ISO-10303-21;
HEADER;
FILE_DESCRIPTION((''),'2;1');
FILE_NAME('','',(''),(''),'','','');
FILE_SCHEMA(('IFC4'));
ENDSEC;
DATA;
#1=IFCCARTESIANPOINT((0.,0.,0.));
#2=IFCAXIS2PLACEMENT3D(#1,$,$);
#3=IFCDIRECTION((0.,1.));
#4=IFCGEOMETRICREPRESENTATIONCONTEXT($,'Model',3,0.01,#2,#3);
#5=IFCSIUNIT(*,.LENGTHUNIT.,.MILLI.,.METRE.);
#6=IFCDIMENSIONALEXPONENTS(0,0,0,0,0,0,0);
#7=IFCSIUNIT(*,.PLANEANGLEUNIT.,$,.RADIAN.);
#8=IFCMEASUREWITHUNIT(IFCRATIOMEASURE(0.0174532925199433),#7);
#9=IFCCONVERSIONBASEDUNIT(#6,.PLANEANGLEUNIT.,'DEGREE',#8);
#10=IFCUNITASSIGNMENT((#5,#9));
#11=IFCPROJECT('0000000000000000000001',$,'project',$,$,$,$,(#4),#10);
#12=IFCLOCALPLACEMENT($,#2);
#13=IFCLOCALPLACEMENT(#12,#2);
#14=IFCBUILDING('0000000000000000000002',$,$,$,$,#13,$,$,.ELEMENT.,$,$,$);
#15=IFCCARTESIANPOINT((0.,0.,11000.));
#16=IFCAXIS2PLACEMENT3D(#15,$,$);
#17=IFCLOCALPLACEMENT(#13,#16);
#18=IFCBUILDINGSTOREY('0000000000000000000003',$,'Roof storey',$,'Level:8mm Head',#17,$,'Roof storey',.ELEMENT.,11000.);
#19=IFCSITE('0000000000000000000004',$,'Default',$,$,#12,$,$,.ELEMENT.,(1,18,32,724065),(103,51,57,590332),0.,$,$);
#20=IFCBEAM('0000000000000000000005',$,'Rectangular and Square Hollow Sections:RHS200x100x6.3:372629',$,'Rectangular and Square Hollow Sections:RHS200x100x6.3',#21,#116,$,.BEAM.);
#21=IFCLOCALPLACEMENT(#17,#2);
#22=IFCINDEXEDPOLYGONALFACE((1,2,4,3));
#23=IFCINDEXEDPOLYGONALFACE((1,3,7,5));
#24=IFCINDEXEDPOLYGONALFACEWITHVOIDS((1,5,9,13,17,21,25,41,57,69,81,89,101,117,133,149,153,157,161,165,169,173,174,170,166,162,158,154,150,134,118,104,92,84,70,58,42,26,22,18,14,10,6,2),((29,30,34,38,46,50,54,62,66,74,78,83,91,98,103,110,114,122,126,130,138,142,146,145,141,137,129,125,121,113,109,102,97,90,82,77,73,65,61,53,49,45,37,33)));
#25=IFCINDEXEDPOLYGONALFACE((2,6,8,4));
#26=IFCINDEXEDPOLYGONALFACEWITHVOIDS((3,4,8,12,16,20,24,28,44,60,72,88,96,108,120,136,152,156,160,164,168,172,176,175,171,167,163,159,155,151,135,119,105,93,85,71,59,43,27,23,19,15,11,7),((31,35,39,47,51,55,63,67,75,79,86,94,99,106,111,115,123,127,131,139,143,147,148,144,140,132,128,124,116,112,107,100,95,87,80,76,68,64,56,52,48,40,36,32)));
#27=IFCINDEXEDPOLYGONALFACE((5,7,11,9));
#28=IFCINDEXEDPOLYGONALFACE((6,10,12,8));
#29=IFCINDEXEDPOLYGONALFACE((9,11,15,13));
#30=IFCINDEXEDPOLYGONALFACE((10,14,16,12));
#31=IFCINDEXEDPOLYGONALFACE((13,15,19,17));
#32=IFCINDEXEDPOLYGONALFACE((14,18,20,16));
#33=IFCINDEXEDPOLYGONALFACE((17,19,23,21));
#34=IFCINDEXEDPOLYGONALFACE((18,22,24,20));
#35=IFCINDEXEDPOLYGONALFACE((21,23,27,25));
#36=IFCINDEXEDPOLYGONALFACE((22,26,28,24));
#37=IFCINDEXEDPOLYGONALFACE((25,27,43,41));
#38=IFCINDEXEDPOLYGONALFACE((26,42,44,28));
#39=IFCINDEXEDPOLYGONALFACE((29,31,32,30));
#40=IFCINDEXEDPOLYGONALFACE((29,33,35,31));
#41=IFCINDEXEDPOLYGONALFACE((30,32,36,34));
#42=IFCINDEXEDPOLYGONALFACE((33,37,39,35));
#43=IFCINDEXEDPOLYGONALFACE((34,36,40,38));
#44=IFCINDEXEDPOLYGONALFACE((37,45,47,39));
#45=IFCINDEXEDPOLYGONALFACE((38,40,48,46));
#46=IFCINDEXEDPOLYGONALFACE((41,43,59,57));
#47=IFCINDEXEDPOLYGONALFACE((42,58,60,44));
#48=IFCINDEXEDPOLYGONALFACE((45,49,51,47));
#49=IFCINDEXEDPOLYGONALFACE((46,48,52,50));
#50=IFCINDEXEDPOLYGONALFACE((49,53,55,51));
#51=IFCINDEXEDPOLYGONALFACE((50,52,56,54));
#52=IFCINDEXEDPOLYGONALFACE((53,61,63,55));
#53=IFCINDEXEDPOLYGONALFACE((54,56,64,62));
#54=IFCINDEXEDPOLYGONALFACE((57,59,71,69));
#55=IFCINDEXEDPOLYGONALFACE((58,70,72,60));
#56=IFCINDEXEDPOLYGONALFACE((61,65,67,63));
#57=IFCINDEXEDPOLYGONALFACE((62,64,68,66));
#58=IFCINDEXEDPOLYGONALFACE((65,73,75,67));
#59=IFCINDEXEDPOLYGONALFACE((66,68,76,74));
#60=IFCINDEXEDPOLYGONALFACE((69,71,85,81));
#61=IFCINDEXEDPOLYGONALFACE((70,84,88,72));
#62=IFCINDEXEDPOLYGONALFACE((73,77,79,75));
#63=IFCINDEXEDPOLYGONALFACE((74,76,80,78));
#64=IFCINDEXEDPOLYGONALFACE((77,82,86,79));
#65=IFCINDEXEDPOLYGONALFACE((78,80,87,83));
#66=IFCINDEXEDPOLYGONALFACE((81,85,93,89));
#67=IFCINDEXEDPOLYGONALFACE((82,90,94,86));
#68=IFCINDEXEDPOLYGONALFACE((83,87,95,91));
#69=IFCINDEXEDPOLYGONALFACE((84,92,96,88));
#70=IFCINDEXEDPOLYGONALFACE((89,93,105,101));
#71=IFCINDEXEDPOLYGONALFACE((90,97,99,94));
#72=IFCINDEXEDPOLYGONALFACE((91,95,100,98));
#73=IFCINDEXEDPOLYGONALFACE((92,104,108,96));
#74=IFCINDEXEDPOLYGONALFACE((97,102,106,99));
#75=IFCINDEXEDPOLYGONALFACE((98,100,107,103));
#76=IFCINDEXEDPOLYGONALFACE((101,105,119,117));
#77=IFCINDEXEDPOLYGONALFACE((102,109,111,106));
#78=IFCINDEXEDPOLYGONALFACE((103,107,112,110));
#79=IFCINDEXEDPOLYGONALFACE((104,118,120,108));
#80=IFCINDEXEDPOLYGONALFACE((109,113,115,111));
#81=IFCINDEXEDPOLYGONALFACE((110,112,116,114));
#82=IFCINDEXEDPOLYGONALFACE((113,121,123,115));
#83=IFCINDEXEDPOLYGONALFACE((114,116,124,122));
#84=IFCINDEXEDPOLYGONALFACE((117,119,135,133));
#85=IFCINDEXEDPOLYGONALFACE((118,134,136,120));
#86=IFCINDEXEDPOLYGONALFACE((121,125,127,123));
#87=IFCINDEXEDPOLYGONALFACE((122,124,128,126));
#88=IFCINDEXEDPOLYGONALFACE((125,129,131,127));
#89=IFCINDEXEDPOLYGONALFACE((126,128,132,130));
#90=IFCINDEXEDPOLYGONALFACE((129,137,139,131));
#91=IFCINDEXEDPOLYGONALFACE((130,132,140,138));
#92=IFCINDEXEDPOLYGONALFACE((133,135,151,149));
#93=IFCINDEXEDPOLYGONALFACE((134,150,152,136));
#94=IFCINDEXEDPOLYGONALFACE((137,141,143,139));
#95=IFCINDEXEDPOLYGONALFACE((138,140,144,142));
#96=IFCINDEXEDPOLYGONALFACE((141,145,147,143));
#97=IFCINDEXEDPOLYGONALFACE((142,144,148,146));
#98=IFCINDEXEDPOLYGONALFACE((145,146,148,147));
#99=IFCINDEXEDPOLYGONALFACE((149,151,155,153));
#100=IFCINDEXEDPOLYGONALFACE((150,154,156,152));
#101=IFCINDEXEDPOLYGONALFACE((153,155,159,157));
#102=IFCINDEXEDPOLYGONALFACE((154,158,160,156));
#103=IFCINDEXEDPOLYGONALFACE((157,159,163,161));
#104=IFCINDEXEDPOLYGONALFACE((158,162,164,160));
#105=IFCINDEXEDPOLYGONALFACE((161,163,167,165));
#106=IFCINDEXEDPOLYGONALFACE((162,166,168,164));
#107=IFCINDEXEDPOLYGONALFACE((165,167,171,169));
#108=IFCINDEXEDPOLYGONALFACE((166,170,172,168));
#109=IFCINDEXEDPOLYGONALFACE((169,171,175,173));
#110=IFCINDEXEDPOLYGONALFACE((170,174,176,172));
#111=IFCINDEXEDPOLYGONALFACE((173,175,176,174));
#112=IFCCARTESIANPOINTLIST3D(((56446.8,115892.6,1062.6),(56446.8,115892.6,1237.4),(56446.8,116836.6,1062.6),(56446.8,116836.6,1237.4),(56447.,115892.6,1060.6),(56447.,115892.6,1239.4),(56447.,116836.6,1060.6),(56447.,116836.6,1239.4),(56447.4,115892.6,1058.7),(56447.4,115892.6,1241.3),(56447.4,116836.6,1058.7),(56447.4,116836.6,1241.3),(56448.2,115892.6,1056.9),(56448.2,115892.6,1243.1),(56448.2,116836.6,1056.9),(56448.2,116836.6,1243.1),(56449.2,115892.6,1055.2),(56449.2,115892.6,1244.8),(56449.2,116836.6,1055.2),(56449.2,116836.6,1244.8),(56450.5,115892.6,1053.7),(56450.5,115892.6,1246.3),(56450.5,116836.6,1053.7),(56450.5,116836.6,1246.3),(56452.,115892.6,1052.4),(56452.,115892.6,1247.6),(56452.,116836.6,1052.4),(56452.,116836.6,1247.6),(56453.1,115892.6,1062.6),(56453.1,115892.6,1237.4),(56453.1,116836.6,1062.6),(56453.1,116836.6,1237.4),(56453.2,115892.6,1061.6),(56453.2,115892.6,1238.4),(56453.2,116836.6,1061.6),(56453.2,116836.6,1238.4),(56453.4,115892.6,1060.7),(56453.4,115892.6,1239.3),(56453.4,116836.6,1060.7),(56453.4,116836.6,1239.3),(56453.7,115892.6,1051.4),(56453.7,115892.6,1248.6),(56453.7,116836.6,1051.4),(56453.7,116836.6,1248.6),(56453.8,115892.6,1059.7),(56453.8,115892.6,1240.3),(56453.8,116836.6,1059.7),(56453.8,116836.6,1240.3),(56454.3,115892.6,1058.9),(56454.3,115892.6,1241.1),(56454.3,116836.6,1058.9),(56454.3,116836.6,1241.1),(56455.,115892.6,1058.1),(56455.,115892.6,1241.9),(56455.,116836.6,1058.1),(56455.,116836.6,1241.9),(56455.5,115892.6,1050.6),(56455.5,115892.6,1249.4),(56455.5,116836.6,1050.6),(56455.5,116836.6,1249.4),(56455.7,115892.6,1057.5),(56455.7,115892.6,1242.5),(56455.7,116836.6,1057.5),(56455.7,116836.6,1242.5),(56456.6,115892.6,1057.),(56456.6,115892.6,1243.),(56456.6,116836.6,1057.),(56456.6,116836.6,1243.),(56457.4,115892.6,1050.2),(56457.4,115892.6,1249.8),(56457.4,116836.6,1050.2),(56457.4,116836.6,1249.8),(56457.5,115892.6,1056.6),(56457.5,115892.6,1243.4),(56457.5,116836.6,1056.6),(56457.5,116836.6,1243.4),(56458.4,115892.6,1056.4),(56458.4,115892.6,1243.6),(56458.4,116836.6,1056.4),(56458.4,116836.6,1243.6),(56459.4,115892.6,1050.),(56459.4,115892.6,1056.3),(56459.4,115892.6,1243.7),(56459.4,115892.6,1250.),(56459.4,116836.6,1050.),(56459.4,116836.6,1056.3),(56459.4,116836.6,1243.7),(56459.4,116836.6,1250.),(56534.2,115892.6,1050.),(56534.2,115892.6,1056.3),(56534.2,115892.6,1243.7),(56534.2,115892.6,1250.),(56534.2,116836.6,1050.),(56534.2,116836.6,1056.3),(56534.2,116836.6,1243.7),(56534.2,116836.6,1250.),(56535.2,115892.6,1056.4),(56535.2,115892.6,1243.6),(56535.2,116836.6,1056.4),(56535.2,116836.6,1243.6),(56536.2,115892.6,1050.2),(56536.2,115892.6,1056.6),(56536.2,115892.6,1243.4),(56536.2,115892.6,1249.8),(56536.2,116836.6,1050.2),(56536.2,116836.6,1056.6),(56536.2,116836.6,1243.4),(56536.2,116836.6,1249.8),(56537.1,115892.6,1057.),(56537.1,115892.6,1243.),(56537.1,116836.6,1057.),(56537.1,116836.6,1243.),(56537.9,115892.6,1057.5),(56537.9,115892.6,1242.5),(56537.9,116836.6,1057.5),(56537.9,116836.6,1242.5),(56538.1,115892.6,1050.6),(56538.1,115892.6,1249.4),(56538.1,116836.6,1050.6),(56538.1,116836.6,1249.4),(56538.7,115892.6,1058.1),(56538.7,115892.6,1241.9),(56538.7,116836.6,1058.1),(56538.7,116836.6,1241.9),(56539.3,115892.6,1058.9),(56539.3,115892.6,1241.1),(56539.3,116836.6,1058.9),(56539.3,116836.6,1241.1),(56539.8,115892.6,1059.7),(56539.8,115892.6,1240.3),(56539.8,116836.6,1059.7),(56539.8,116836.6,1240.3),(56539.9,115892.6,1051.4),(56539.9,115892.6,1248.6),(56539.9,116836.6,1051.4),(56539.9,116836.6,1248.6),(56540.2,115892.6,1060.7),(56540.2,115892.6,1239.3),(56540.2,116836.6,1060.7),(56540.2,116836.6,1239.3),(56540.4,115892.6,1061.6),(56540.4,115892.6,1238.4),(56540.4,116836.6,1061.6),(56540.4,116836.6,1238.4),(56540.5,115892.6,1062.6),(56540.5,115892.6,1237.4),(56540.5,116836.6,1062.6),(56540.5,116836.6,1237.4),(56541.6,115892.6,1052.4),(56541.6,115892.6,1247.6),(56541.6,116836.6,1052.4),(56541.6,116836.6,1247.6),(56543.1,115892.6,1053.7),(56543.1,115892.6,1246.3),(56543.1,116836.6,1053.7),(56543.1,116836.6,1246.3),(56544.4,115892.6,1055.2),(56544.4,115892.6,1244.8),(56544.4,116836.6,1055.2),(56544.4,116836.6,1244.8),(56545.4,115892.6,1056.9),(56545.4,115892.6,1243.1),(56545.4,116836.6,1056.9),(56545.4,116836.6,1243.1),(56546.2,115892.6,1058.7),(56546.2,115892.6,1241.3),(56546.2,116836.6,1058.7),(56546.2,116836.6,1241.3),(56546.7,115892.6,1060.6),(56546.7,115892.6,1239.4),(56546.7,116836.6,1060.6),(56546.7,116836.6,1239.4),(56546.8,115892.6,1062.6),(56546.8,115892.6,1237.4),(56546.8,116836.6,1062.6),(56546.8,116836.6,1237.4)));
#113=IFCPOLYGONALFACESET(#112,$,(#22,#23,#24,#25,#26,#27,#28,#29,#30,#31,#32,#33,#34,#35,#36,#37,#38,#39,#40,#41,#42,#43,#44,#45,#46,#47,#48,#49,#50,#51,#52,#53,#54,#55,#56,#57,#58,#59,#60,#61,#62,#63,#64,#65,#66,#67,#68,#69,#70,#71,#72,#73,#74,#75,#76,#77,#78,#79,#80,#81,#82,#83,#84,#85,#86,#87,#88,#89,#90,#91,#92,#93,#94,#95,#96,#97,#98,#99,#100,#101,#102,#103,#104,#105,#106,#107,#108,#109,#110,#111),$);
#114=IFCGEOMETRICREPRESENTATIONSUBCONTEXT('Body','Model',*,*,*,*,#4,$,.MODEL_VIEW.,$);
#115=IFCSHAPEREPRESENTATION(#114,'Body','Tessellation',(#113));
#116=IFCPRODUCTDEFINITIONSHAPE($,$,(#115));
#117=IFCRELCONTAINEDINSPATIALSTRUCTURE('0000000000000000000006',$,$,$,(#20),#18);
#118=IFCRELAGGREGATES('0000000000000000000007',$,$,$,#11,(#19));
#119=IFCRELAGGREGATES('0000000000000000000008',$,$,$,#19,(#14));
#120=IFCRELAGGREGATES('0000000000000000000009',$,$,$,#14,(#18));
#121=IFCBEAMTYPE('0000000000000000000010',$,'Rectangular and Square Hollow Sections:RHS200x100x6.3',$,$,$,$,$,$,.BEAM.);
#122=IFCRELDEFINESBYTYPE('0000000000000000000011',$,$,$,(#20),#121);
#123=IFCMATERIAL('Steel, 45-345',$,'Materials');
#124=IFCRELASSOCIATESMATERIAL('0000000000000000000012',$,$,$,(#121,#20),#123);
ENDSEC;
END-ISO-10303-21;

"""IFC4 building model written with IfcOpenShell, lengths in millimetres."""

from ifc_helpers import new_model, entity, si_unit, converted_unit, direction, frame, origin, place, context, subcontext, project, spatial, indexed_curve, outline, extrude, source, transform, mapped, material, type_object, type_shapes, element, save


model = new_model("IFC4")

# Units and contexts
model_context = context("Model", 3, precision=0.01, world=origin(), true_north=direction((0.0, 1.0)))
body_context = subcontext(model_context, "Body", "Model", "MODEL_VIEW")
ifc_project = project(units=[si_unit("LENGTHUNIT", "METRE", prefix="MILLI"), converted_unit("PLANEANGLEUNIT", "DEGREE", entity("IfcRatioMeasure", 0.0174532925199433), si_unit("PLANEANGLEUNIT", "RADIAN"), dimensions=[0, 0, 0, 0, 0, 0, 0])], contexts=[model_context])

# Site, building, storey
site_placement = place(None, origin())
site = spatial("IfcSite", under=ifc_project, at=site_placement, Name="Default", CompositionType="ELEMENT", RefLatitude=(1, 18, 32, 724065), RefLongitude=(103, 51, 57, 590332), RefElevation=0.0)
building_placement = place(site_placement, origin())
building = spatial("IfcBuilding", under=site, at=building_placement, CompositionType="ELEMENT")
storey_placement = place(building_placement, frame((0.0, 0.0, 11000.0)))
storey = spatial("IfcBuildingStorey", under=building, at=storey_placement, Name="Roof storey", ObjectType="Level:8mm Head", LongName="Roof storey", CompositionType="ELEMENT", Elevation=11000.0)

# Shared definitions
ifc_material = material(Name="Steel, 45-345", Category="Materials")

# Beam
beam_type_1 = type_object("IfcBeamType", Name="Rectangular and Square Hollow Sections:RHS200x100x6.3", PredefinedType="BEAM", material=ifc_material)
shared_shape_1 = source(origin(), body_context, "Body", "SweptSolid", [
    extrude(outline(indexed_curve([(-50.0, -87.4), (-49.8, -89.4), (-49.4, -91.3), (-48.6, -93.1), (-47.6, -94.8), (-46.3, -96.3), (-44.8, -97.6), (-43.1, -98.6), (-41.3, -99.4), (-39.4, -99.8), (-37.4, -100.0), (37.4, -100.0), (39.4, -99.8), (41.3, -99.4), (43.1, -98.6), (44.8, -97.6), (46.3, -96.3), (47.6, -94.8), (48.6, -93.1), (49.4, -91.3), (49.8, -89.4), (50.0, -87.4), (50.0, 87.4), (49.8, 89.4), (49.4, 91.3), (48.6, 93.1), (47.6, 94.8), (46.3, 96.3), (44.8, 97.6), (43.1, 98.6), (41.3, 99.4), (39.4, 99.8), (37.4, 100.0), (-37.4, 100.0), (-39.4, 99.8), (-41.3, 99.4), (-43.1, 98.6), (-44.8, 97.6), (-46.3, 96.3), (-47.6, 94.8), (-48.6, 93.1), (-49.4, 91.3), (-49.8, 89.4), (-50.0, 87.4), (-50.0, -87.4)], self_intersect=False), holes=[indexed_curve([(37.4, -93.7), (-37.4, -93.7), (-38.4, -93.6), (-39.3, -93.4), (-40.3, -93.0), (-41.1, -92.5), (-41.9, -91.9), (-42.5, -91.1), (-43.0, -90.3), (-43.4, -89.3), (-43.6, -88.4), (-43.7, -87.4), (-43.7, 87.4), (-43.6, 88.4), (-43.4, 89.3), (-43.0, 90.3), (-42.5, 91.1), (-41.9, 91.9), (-41.1, 92.5), (-40.3, 93.0), (-39.3, 93.4), (-38.4, 93.6), (-37.4, 93.7), (37.4, 93.7), (38.4, 93.6), (39.3, 93.4), (40.3, 93.0), (41.1, 92.5), (41.9, 91.9), (42.5, 91.1), (43.0, 90.3), (43.4, 89.3), (43.6, 88.4), (43.7, 87.4), (43.7, -87.4), (43.6, -88.4), (43.4, -89.3), (43.0, -90.3), (42.5, -91.1), (41.9, -91.9), (41.1, -92.5), (40.3, -93.0), (39.3, -93.4), (38.4, -93.6), (37.4, -93.7)], self_intersect=False)]), frame((-487.0, 0.0, 0.0), z_axis=(1.0, 0.0, 0.0), x_axis=(0.0, -1.0, 0.0)), (0.0, 0.0, 1.0), 944.0),
])
type_shapes(beam_type_1, [shared_shape_1])
beam_1_placement = place(storey_placement, frame((56496.8, 116379.6, 1150.0), z_axis=(0.0, 0.0, 1.0), x_axis=(0.0, 1.0, 0.0)))
element("IfcBeam", 1, at=beam_1_placement, inside=storey, type_object=beam_type_1, material=ifc_material, Name="Rectangular and Square Hollow Sections:RHS200x100x6.3:372629", ObjectType="Rectangular and Square Hollow Sections:RHS200x100x6.3", PredefinedType="BEAM", context=body_context, shape_type="MappedRepresentation", body=[
    mapped(shared_shape_1, transform((0.0, 0.0, 0.0), scale=1.0)),
])

save(model, "model.ifc")
